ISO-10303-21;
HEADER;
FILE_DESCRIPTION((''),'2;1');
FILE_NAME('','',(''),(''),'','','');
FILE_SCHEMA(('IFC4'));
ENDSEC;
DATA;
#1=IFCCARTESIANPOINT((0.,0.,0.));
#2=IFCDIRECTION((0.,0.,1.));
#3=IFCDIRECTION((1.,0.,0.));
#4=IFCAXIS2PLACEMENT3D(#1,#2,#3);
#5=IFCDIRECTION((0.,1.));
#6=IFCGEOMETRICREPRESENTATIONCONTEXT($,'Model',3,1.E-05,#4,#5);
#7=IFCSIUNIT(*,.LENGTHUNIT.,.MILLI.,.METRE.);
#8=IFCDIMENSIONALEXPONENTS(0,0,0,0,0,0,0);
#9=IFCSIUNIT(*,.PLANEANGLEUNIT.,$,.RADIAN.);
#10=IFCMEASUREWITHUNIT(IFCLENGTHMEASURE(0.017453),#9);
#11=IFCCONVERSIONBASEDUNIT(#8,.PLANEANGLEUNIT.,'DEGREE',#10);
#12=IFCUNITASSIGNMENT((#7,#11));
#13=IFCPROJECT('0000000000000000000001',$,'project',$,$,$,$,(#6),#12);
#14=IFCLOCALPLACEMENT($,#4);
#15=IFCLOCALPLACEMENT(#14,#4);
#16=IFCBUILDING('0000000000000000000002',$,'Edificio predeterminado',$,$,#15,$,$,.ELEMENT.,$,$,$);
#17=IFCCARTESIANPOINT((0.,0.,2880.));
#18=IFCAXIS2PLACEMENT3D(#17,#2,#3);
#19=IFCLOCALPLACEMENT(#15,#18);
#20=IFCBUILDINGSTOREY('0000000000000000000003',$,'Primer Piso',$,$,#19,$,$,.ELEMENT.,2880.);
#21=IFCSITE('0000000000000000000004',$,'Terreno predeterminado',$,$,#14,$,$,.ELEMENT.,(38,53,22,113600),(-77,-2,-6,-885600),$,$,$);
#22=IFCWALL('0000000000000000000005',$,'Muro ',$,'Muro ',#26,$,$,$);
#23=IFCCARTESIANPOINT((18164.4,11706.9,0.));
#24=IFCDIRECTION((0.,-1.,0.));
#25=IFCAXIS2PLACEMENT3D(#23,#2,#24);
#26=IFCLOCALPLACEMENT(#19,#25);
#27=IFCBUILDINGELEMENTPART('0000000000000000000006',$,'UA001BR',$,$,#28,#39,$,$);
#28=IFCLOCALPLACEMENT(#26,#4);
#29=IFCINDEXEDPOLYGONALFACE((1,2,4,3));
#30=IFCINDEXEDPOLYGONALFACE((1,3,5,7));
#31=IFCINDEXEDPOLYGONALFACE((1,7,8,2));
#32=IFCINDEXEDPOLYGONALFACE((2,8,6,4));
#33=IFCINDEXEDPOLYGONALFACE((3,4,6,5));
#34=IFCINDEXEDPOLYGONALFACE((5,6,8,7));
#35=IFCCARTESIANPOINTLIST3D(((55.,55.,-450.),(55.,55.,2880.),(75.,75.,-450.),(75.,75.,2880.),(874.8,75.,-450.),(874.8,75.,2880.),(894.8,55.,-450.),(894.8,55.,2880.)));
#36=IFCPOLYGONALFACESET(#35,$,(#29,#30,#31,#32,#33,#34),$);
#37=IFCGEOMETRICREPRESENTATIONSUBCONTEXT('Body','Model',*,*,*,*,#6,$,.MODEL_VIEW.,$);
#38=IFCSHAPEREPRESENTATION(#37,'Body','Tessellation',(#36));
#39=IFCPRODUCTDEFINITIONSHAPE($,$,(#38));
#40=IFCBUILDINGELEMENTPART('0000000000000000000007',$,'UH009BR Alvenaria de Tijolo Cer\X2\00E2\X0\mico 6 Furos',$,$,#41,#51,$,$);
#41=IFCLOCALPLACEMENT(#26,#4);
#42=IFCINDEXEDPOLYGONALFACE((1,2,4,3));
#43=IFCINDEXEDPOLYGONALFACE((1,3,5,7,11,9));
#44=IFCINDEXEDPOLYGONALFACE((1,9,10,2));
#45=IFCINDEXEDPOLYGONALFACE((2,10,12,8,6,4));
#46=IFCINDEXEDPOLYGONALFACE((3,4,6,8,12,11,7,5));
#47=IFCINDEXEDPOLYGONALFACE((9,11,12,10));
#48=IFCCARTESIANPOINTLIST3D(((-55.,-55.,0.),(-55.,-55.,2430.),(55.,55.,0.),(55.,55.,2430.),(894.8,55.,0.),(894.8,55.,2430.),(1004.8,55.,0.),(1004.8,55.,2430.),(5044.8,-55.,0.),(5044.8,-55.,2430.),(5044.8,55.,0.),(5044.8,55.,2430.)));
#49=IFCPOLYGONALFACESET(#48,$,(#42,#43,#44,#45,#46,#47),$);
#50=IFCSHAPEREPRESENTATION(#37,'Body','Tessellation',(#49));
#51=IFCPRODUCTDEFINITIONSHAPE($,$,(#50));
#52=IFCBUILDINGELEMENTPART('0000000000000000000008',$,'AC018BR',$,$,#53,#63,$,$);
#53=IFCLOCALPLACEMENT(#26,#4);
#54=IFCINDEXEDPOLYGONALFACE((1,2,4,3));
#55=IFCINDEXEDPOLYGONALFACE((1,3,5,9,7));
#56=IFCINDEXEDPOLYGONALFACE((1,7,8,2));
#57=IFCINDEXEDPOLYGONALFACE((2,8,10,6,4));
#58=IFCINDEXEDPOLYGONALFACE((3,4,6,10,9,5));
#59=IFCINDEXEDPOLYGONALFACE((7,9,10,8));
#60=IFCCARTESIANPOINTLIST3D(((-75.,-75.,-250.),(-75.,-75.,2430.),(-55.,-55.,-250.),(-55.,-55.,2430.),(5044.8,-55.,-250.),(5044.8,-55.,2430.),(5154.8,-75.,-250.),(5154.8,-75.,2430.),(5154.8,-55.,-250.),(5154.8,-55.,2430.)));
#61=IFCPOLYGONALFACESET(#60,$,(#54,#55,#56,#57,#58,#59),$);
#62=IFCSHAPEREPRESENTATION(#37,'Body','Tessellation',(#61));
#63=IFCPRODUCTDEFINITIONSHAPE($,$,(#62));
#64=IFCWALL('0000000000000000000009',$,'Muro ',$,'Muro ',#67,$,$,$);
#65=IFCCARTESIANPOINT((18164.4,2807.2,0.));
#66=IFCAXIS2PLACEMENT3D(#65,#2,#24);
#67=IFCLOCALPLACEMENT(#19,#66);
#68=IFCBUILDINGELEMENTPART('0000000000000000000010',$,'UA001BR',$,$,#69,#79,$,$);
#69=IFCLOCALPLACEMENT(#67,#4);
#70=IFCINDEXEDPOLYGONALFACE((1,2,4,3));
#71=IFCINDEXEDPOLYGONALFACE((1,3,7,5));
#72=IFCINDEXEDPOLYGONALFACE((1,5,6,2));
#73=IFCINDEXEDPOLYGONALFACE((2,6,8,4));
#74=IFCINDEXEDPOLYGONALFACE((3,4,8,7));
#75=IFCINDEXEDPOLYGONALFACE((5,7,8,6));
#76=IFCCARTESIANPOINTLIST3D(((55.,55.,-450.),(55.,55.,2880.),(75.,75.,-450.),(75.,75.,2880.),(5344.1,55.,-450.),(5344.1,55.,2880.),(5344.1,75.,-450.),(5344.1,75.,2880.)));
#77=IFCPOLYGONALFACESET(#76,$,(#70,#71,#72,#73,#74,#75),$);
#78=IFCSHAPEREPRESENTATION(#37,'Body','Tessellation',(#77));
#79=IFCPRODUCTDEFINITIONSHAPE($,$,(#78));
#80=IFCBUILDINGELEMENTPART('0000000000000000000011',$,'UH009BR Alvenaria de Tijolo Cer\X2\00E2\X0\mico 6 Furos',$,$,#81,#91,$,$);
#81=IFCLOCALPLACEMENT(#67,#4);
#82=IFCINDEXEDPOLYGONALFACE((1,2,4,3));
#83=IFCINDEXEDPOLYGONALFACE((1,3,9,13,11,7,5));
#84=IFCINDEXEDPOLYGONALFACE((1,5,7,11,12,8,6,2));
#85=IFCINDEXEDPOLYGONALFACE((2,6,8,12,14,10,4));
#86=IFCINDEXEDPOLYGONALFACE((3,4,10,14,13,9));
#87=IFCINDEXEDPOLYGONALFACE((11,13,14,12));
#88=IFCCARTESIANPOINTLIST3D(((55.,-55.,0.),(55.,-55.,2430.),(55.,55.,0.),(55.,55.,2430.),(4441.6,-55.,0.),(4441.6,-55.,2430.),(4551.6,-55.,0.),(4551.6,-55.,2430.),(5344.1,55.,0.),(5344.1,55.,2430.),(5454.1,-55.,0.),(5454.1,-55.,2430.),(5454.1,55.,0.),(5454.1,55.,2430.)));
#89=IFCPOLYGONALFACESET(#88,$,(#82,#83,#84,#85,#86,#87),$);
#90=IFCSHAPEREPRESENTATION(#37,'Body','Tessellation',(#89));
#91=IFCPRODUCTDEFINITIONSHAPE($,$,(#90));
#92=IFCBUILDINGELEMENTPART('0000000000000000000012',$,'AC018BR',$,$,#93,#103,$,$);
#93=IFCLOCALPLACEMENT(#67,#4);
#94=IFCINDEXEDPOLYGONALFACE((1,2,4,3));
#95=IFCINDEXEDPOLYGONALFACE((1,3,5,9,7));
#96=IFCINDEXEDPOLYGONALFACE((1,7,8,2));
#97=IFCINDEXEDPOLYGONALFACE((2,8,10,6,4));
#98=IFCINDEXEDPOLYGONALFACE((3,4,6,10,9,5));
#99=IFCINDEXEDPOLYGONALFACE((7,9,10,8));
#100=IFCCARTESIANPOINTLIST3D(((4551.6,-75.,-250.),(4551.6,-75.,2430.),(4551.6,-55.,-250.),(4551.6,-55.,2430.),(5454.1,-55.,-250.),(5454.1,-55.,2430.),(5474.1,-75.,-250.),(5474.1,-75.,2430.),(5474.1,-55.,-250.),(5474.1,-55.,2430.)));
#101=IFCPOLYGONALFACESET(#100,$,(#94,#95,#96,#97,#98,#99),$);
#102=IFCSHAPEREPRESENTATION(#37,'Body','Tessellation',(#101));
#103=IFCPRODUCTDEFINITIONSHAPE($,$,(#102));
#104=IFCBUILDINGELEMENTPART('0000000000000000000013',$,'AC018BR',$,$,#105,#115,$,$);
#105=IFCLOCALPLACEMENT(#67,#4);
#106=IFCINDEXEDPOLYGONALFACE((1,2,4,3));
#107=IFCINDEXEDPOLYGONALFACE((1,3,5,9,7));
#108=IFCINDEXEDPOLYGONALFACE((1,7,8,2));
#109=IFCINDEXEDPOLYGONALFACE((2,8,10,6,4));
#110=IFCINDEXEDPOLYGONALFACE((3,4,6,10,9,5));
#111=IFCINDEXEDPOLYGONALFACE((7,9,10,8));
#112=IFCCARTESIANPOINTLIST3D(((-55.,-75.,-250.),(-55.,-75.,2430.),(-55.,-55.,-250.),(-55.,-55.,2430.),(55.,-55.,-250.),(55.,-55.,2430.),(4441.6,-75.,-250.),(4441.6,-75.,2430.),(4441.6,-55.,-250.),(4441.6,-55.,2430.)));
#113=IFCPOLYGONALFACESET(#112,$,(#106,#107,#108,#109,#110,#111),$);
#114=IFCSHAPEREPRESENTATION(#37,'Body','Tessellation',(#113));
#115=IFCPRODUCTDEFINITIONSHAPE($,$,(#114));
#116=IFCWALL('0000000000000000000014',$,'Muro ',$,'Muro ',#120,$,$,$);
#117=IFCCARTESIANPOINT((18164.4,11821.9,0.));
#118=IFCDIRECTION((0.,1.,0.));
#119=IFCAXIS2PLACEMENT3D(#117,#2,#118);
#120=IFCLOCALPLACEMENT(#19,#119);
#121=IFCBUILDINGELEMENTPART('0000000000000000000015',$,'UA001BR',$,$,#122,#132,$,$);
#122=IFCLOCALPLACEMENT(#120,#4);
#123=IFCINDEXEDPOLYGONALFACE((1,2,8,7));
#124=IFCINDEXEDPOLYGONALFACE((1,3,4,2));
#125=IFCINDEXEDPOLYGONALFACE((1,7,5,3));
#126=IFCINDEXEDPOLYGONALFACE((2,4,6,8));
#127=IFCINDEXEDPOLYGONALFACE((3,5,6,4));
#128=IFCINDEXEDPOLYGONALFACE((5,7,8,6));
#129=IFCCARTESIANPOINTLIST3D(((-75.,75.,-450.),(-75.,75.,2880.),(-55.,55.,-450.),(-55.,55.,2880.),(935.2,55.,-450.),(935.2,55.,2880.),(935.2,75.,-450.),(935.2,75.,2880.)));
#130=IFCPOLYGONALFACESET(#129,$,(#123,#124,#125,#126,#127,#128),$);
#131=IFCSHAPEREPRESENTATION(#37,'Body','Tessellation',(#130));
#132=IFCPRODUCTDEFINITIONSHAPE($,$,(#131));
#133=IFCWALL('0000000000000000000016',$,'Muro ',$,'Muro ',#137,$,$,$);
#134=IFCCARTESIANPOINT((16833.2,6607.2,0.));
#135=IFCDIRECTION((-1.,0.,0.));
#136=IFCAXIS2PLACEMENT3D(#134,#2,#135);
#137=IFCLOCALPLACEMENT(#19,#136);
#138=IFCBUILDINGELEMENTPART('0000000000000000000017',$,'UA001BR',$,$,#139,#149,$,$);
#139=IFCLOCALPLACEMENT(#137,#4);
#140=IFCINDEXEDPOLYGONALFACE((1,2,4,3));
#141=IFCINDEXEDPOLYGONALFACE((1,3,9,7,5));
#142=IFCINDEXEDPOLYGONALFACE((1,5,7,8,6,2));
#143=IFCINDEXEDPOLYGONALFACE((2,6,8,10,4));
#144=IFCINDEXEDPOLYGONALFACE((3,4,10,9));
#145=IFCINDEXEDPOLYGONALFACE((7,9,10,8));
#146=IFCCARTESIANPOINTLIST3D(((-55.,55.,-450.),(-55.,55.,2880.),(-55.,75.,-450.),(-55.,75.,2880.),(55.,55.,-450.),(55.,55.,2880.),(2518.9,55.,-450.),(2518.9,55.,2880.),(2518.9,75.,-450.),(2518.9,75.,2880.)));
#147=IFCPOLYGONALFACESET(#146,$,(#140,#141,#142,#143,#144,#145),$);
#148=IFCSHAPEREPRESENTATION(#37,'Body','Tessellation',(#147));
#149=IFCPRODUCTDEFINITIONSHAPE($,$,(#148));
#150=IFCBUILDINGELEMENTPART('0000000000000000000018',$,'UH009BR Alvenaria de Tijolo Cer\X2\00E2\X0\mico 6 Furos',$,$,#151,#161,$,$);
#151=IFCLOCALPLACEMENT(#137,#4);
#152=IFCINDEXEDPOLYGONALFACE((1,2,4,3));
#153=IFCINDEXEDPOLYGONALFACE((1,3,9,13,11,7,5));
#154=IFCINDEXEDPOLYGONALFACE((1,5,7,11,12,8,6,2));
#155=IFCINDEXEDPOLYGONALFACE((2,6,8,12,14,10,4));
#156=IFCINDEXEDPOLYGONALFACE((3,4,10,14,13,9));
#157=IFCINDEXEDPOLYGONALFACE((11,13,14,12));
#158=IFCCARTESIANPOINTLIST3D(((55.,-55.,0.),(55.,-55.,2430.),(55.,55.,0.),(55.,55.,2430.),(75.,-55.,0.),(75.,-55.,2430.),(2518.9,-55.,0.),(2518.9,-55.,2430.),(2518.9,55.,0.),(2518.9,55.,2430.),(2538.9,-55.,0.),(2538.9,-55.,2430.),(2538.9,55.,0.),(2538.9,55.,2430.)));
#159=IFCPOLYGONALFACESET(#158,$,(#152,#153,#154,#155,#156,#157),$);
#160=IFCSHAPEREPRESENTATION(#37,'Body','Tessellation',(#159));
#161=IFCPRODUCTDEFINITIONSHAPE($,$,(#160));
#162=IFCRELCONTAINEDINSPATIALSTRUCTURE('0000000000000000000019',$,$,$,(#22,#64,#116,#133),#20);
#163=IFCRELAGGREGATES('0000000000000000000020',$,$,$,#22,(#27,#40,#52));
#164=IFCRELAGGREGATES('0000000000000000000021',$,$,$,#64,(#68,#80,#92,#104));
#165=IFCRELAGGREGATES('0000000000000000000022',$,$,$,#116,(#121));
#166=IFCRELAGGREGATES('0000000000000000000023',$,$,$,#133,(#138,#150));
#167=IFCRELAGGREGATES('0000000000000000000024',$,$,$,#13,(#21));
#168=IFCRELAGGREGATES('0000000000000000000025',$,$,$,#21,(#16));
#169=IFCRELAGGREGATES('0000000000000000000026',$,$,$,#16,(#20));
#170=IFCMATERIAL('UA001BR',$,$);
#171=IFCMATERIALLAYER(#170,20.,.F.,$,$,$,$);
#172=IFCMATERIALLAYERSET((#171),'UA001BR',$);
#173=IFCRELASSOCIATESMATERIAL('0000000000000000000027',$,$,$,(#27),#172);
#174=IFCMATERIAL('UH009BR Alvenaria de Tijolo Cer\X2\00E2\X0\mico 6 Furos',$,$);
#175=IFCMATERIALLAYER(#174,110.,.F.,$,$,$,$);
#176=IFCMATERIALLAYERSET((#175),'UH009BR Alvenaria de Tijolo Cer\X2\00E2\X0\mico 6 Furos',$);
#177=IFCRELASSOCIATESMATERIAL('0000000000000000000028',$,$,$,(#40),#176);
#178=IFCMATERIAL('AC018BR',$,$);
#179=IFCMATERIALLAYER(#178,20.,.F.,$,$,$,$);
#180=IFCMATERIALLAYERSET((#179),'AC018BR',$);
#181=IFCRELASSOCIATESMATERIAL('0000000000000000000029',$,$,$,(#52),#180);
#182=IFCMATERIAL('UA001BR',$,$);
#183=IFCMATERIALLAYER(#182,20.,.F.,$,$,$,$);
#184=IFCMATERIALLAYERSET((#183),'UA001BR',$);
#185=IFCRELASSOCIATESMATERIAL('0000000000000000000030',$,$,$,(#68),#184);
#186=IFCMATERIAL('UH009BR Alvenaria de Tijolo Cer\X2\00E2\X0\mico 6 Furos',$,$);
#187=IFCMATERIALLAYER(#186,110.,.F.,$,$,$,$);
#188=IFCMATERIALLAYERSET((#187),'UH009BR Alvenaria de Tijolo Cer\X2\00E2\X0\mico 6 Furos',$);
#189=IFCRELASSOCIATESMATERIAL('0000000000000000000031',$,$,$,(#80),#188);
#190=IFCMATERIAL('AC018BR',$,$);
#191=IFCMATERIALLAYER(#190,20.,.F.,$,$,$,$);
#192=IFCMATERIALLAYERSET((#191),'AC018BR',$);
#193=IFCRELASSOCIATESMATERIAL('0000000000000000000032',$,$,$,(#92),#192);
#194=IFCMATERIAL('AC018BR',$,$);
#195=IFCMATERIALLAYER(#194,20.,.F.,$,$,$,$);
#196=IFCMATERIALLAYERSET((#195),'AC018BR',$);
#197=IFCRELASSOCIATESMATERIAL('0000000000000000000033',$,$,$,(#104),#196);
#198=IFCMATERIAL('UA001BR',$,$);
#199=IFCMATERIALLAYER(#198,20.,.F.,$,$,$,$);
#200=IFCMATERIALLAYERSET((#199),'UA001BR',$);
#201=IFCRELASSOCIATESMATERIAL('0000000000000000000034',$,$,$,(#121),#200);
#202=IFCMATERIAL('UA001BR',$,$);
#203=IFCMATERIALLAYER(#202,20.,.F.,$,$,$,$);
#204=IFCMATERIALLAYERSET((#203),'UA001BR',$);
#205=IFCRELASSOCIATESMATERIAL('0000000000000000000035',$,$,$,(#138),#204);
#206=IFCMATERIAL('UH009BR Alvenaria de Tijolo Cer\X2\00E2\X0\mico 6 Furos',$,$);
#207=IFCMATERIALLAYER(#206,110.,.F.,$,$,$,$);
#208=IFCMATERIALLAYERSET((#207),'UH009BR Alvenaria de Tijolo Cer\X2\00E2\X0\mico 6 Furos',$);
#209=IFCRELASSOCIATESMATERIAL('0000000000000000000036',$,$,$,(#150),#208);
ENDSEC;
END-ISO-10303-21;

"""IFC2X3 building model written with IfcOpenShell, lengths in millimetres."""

from ifc_helpers import new_model, entity, si_unit, converted_unit, direction, frame, origin_with_axes, place, context, subcontext, project, spatial, polyline, outline, extrude, material, layer, layer_set, layer_usage, element, aggregate, save


model = new_model("IFC2X3")

# Units and contexts
model_context = context("Model", 3, precision=1e-05, world=origin_with_axes(), true_north=direction((0.0, 1.0)))
body_context = subcontext(model_context, "Body", "Model", "MODEL_VIEW")
ifc_project = project(units=[si_unit("LENGTHUNIT", "METRE", prefix="MILLI"), converted_unit("PLANEANGLEUNIT", "DEGREE", entity("IfcLengthMeasure", 0.017453), si_unit("PLANEANGLEUNIT", "RADIAN"), dimensions=[0, 0, 0, 0, 0, 0, 0])], contexts=[model_context])

# Site, building, storey
site_placement = place(None, origin_with_axes())
site = spatial("IfcSite", under=ifc_project, at=site_placement, Name="Terreno predeterminado", CompositionType="ELEMENT", RefLatitude=(38, 53, 22, 113600), RefLongitude=(-77, -2, -6, -885600))
building_placement = place(site_placement, origin_with_axes())
building = spatial("IfcBuilding", under=site, at=building_placement, Name="Edificio predeterminado", CompositionType="ELEMENT")
storey_placement = place(building_placement, frame((0.0, 0.0, 2880.0), z_axis=(0.0, 0.0, 1.0), x_axis=(1.0, 0.0, 0.0)))
storey = spatial("IfcBuildingStorey", under=building, at=storey_placement, Name="Primer Piso", CompositionType="ELEMENT", Elevation=2880.0)

# Walls, building element parts
wall_1_placement = place(storey_placement, frame((18164.4, 11706.9, 0.0), z_axis=(0.0, 0.0, 1.0), x_axis=(0.0, -1.0, 0.0)))
wall_1 = element("IfcWall", 1, at=wall_1_placement, inside=storey, Name="Muro ", ObjectType="Muro ")
ifc_material_1 = material(Name="UA001BR")
ifc_layer_1 = layer(ifc_material_1, 20.0, ventilated=False)
ifc_layer_set_1 = layer_set([ifc_layer_1], Name="UA001BR")
ifc_layer_usage_1 = layer_usage(ifc_layer_set_1, "AXIS2", "NEGATIVE", -75.0)
building_element_part_1_placement = place(wall_1_placement, origin_with_axes())
building_element_part_1 = element("IfcBuildingElementPart", 2, at=building_element_part_1_placement, material=ifc_layer_usage_1, Name="UA001BR", context=body_context, shape_type="SweptSolid", body=[
    extrude(outline(polyline([(874.8, 75.0), (894.8, 55.0), (55.0, 55.0), (75.0, 75.0), (874.8, 75.0)])), frame((0.0, 0.0, -450.0), z_axis=(0.0, 0.0, 1.0), x_axis=(1.0, 0.0, 0.0)), (0.0, 0.0, 1.0), 3330.0),
])
ifc_material_2 = material(Name="UH009BR Alvenaria de Tijolo Cerâmico 6 Furos")
ifc_layer_2 = layer(ifc_material_2, 110.0, ventilated=False)
ifc_layer_set_2 = layer_set([ifc_layer_2], Name="UH009BR Alvenaria de Tijolo Cerâmico 6 Furos")
ifc_layer_usage_2 = layer_usage(ifc_layer_set_2, "AXIS2", "NEGATIVE", -55.0)
building_element_part_2_placement = place(wall_1_placement, origin_with_axes())
building_element_part_2 = element("IfcBuildingElementPart", 3, at=building_element_part_2_placement, material=ifc_layer_usage_2, Name="UH009BR Alvenaria de Tijolo Cerâmico 6 Furos", context=body_context, shape_type="SweptSolid", body=[
    extrude(outline(polyline([(5044.8, 55.0), (5044.8, -55.0), (-55.0, -55.0), (55.0, 55.0), (894.8, 55.0), (1004.8, 55.0), (5044.8, 55.0)])), origin_with_axes(), (0.0, 0.0, 1.0), 2430.0),
])
ifc_material_3 = material(Name="AC018BR")
ifc_layer_3 = layer(ifc_material_3, 20.0, ventilated=False)
ifc_layer_set_3 = layer_set([ifc_layer_3], Name="AC018BR")
ifc_layer_usage_3 = layer_usage(ifc_layer_set_3, "AXIS2", "NEGATIVE", 55.0)
building_element_part_3_placement = place(wall_1_placement, origin_with_axes())
building_element_part_3 = element("IfcBuildingElementPart", 4, at=building_element_part_3_placement, material=ifc_layer_usage_3, Name="AC018BR", context=body_context, shape_type="SweptSolid", body=[
    extrude(outline(polyline([(5154.8, -55.0), (5154.8, -75.0), (-75.0, -75.0), (-55.0, -55.0), (5044.8, -55.0), (5154.8, -55.0)])), frame((0.0, 0.0, -250.0), z_axis=(0.0, 0.0, 1.0), x_axis=(1.0, 0.0, 0.0)), (0.0, 0.0, 1.0), 2680.0),
])
aggregate(wall_1, [building_element_part_1, building_element_part_2, building_element_part_3])
wall_2_placement = place(storey_placement, frame((18164.4, 2807.2, 0.0), z_axis=(0.0, 0.0, 1.0), x_axis=(0.0, -1.0, 0.0)))
wall_2 = element("IfcWall", 5, at=wall_2_placement, inside=storey, Name="Muro ", ObjectType="Muro ")
ifc_material_4 = material(Name="UA001BR")
ifc_layer_4 = layer(ifc_material_4, 20.0, ventilated=False)
ifc_layer_set_4 = layer_set([ifc_layer_4], Name="UA001BR")
ifc_layer_usage_4 = layer_usage(ifc_layer_set_4, "AXIS2", "NEGATIVE", -75.0)
building_element_part_4_placement = place(wall_2_placement, origin_with_axes())
building_element_part_4 = element("IfcBuildingElementPart", 6, at=building_element_part_4_placement, material=ifc_layer_usage_4, Name="UA001BR", context=body_context, shape_type="SweptSolid", body=[
    extrude(outline(polyline([(5344.1, 75.0), (5344.1, 55.0), (55.0, 55.0), (75.0, 75.0), (5344.1, 75.0)])), frame((0.0, 0.0, -450.0), z_axis=(0.0, 0.0, 1.0), x_axis=(1.0, 0.0, 0.0)), (0.0, 0.0, 1.0), 3330.0),
])
ifc_material_5 = material(Name="UH009BR Alvenaria de Tijolo Cerâmico 6 Furos")
ifc_layer_5 = layer(ifc_material_5, 110.0, ventilated=False)
ifc_layer_set_5 = layer_set([ifc_layer_5], Name="UH009BR Alvenaria de Tijolo Cerâmico 6 Furos")
ifc_layer_usage_5 = layer_usage(ifc_layer_set_5, "AXIS2", "NEGATIVE", -55.0)
building_element_part_5_placement = place(wall_2_placement, origin_with_axes())
building_element_part_5 = element("IfcBuildingElementPart", 7, at=building_element_part_5_placement, material=ifc_layer_usage_5, Name="UH009BR Alvenaria de Tijolo Cerâmico 6 Furos", context=body_context, shape_type="SweptSolid", body=[
    extrude(outline(polyline([(5454.1, 55.0), (5454.1, -55.0), (4551.6, -55.0), (4441.6, -55.0), (55.0, -55.0), (55.0, 55.0), (5344.1, 55.0), (5454.1, 55.0)])), origin_with_axes(), (0.0, 0.0, 1.0), 2430.0),
])
ifc_material_6 = material(Name="AC018BR")
ifc_layer_6 = layer(ifc_material_6, 20.0, ventilated=False)
ifc_layer_set_6 = layer_set([ifc_layer_6], Name="AC018BR")
ifc_layer_usage_6 = layer_usage(ifc_layer_set_6, "AXIS2", "NEGATIVE", 55.0)
building_element_part_6_placement = place(wall_2_placement, origin_with_axes())
building_element_part_6 = element("IfcBuildingElementPart", 8, at=building_element_part_6_placement, material=ifc_layer_usage_6, Name="AC018BR", context=body_context, shape_type="SweptSolid", body=[
    extrude(outline(polyline([(5474.1, -55.0), (5474.1, -75.0), (4551.6, -75.0), (4551.6, -55.0), (5454.1, -55.0), (5474.1, -55.0)])), frame((0.0, 0.0, -250.0), z_axis=(0.0, 0.0, 1.0), x_axis=(1.0, 0.0, 0.0)), (0.0, 0.0, 1.0), 2680.0),
])
ifc_material_7 = material(Name="AC018BR")
ifc_layer_7 = layer(ifc_material_7, 20.0, ventilated=False)
ifc_layer_set_7 = layer_set([ifc_layer_7], Name="AC018BR")
ifc_layer_usage_7 = layer_usage(ifc_layer_set_7, "AXIS2", "NEGATIVE", 55.0)
building_element_part_7_placement = place(wall_2_placement, origin_with_axes())
building_element_part_7 = element("IfcBuildingElementPart", 9, at=building_element_part_7_placement, material=ifc_layer_usage_7, Name="AC018BR", context=body_context, shape_type="SweptSolid", body=[
    extrude(outline(polyline([(4441.6, -55.0), (4441.6, -75.0), (-55.0, -75.0), (-55.0, -55.0), (55.0, -55.0), (4441.6, -55.0)])), frame((0.0, 0.0, -250.0), z_axis=(0.0, 0.0, 1.0), x_axis=(1.0, 0.0, 0.0)), (0.0, 0.0, 1.0), 2680.0),
])
aggregate(wall_2, [building_element_part_4, building_element_part_5, building_element_part_6, building_element_part_7])

# Wall, building element part
wall_3_placement = place(storey_placement, frame((18164.4, 11821.9, 0.0), z_axis=(0.0, 0.0, 1.0), x_axis=(0.0, 1.0, 0.0)))
wall_3 = element("IfcWall", 10, at=wall_3_placement, inside=storey, Name="Muro ", ObjectType="Muro ")
ifc_material_8 = material(Name="UA001BR")
ifc_layer_8 = layer(ifc_material_8, 20.0, ventilated=False)
ifc_layer_set_8 = layer_set([ifc_layer_8], Name="UA001BR")
ifc_layer_usage_8 = layer_usage(ifc_layer_set_8, "AXIS2", "NEGATIVE", -75.0)
building_element_part_8_placement = place(wall_3_placement, origin_with_axes())
building_element_part_8 = element("IfcBuildingElementPart", 11, at=building_element_part_8_placement, material=ifc_layer_usage_8, Name="UA001BR", context=body_context, shape_type="SweptSolid", body=[
    extrude(outline(polyline([(935.2, 75.0), (935.2, 55.0), (-55.0, 55.0), (-75.0, 75.0), (935.2, 75.0)])), frame((0.0, 0.0, -450.0), z_axis=(0.0, 0.0, 1.0), x_axis=(1.0, 0.0, 0.0)), (0.0, 0.0, 1.0), 3330.0),
])
aggregate(wall_3, [building_element_part_8])

# Wall, building element parts
wall_4_placement = place(storey_placement, frame((16833.2, 6607.2, 0.0), z_axis=(0.0, 0.0, 1.0), x_axis=(-1.0, 0.0, 0.0)))
wall_4 = element("IfcWall", 12, at=wall_4_placement, inside=storey, Name="Muro ", ObjectType="Muro ")
ifc_material_9 = material(Name="UA001BR")
ifc_layer_9 = layer(ifc_material_9, 20.0, ventilated=False)
ifc_layer_set_9 = layer_set([ifc_layer_9], Name="UA001BR")
ifc_layer_usage_9 = layer_usage(ifc_layer_set_9, "AXIS2", "NEGATIVE", -75.0)
building_element_part_9_placement = place(wall_4_placement, origin_with_axes())
building_element_part_9 = element("IfcBuildingElementPart", 13, at=building_element_part_9_placement, material=ifc_layer_usage_9, Name="UA001BR", context=body_context, shape_type="SweptSolid", body=[
    extrude(outline(polyline([(2518.9, 75.0), (2518.9, 55.0), (55.0, 55.0), (-55.0, 55.0), (-55.0, 75.0), (2518.9, 75.0)])), frame((0.0, 0.0, -450.0), z_axis=(0.0, 0.0, 1.0), x_axis=(1.0, 0.0, 0.0)), (0.0, 0.0, 1.0), 3330.0),
])
ifc_material_10 = material(Name="UH009BR Alvenaria de Tijolo Cerâmico 6 Furos")
ifc_layer_10 = layer(ifc_material_10, 110.0, ventilated=False)
ifc_layer_set_10 = layer_set([ifc_layer_10], Name="UH009BR Alvenaria de Tijolo Cerâmico 6 Furos")
ifc_layer_usage_10 = layer_usage(ifc_layer_set_10, "AXIS2", "NEGATIVE", -55.0)
building_element_part_10_placement = place(wall_4_placement, origin_with_axes())
building_element_part_10 = element("IfcBuildingElementPart", 14, at=building_element_part_10_placement, material=ifc_layer_usage_10, Name="UH009BR Alvenaria de Tijolo Cerâmico 6 Furos", context=body_context, shape_type="SweptSolid", body=[
    extrude(outline(polyline([(2538.9, 55.0), (2538.9, -55.0), (2518.9, -55.0), (75.0, -55.0), (55.0, -55.0), (55.0, 55.0), (2518.9, 55.0), (2538.9, 55.0)])), origin_with_axes(), (0.0, 0.0, 1.0), 2430.0),
])
aggregate(wall_4, [building_element_part_9, building_element_part_10])

save(model, "model.ifc")
